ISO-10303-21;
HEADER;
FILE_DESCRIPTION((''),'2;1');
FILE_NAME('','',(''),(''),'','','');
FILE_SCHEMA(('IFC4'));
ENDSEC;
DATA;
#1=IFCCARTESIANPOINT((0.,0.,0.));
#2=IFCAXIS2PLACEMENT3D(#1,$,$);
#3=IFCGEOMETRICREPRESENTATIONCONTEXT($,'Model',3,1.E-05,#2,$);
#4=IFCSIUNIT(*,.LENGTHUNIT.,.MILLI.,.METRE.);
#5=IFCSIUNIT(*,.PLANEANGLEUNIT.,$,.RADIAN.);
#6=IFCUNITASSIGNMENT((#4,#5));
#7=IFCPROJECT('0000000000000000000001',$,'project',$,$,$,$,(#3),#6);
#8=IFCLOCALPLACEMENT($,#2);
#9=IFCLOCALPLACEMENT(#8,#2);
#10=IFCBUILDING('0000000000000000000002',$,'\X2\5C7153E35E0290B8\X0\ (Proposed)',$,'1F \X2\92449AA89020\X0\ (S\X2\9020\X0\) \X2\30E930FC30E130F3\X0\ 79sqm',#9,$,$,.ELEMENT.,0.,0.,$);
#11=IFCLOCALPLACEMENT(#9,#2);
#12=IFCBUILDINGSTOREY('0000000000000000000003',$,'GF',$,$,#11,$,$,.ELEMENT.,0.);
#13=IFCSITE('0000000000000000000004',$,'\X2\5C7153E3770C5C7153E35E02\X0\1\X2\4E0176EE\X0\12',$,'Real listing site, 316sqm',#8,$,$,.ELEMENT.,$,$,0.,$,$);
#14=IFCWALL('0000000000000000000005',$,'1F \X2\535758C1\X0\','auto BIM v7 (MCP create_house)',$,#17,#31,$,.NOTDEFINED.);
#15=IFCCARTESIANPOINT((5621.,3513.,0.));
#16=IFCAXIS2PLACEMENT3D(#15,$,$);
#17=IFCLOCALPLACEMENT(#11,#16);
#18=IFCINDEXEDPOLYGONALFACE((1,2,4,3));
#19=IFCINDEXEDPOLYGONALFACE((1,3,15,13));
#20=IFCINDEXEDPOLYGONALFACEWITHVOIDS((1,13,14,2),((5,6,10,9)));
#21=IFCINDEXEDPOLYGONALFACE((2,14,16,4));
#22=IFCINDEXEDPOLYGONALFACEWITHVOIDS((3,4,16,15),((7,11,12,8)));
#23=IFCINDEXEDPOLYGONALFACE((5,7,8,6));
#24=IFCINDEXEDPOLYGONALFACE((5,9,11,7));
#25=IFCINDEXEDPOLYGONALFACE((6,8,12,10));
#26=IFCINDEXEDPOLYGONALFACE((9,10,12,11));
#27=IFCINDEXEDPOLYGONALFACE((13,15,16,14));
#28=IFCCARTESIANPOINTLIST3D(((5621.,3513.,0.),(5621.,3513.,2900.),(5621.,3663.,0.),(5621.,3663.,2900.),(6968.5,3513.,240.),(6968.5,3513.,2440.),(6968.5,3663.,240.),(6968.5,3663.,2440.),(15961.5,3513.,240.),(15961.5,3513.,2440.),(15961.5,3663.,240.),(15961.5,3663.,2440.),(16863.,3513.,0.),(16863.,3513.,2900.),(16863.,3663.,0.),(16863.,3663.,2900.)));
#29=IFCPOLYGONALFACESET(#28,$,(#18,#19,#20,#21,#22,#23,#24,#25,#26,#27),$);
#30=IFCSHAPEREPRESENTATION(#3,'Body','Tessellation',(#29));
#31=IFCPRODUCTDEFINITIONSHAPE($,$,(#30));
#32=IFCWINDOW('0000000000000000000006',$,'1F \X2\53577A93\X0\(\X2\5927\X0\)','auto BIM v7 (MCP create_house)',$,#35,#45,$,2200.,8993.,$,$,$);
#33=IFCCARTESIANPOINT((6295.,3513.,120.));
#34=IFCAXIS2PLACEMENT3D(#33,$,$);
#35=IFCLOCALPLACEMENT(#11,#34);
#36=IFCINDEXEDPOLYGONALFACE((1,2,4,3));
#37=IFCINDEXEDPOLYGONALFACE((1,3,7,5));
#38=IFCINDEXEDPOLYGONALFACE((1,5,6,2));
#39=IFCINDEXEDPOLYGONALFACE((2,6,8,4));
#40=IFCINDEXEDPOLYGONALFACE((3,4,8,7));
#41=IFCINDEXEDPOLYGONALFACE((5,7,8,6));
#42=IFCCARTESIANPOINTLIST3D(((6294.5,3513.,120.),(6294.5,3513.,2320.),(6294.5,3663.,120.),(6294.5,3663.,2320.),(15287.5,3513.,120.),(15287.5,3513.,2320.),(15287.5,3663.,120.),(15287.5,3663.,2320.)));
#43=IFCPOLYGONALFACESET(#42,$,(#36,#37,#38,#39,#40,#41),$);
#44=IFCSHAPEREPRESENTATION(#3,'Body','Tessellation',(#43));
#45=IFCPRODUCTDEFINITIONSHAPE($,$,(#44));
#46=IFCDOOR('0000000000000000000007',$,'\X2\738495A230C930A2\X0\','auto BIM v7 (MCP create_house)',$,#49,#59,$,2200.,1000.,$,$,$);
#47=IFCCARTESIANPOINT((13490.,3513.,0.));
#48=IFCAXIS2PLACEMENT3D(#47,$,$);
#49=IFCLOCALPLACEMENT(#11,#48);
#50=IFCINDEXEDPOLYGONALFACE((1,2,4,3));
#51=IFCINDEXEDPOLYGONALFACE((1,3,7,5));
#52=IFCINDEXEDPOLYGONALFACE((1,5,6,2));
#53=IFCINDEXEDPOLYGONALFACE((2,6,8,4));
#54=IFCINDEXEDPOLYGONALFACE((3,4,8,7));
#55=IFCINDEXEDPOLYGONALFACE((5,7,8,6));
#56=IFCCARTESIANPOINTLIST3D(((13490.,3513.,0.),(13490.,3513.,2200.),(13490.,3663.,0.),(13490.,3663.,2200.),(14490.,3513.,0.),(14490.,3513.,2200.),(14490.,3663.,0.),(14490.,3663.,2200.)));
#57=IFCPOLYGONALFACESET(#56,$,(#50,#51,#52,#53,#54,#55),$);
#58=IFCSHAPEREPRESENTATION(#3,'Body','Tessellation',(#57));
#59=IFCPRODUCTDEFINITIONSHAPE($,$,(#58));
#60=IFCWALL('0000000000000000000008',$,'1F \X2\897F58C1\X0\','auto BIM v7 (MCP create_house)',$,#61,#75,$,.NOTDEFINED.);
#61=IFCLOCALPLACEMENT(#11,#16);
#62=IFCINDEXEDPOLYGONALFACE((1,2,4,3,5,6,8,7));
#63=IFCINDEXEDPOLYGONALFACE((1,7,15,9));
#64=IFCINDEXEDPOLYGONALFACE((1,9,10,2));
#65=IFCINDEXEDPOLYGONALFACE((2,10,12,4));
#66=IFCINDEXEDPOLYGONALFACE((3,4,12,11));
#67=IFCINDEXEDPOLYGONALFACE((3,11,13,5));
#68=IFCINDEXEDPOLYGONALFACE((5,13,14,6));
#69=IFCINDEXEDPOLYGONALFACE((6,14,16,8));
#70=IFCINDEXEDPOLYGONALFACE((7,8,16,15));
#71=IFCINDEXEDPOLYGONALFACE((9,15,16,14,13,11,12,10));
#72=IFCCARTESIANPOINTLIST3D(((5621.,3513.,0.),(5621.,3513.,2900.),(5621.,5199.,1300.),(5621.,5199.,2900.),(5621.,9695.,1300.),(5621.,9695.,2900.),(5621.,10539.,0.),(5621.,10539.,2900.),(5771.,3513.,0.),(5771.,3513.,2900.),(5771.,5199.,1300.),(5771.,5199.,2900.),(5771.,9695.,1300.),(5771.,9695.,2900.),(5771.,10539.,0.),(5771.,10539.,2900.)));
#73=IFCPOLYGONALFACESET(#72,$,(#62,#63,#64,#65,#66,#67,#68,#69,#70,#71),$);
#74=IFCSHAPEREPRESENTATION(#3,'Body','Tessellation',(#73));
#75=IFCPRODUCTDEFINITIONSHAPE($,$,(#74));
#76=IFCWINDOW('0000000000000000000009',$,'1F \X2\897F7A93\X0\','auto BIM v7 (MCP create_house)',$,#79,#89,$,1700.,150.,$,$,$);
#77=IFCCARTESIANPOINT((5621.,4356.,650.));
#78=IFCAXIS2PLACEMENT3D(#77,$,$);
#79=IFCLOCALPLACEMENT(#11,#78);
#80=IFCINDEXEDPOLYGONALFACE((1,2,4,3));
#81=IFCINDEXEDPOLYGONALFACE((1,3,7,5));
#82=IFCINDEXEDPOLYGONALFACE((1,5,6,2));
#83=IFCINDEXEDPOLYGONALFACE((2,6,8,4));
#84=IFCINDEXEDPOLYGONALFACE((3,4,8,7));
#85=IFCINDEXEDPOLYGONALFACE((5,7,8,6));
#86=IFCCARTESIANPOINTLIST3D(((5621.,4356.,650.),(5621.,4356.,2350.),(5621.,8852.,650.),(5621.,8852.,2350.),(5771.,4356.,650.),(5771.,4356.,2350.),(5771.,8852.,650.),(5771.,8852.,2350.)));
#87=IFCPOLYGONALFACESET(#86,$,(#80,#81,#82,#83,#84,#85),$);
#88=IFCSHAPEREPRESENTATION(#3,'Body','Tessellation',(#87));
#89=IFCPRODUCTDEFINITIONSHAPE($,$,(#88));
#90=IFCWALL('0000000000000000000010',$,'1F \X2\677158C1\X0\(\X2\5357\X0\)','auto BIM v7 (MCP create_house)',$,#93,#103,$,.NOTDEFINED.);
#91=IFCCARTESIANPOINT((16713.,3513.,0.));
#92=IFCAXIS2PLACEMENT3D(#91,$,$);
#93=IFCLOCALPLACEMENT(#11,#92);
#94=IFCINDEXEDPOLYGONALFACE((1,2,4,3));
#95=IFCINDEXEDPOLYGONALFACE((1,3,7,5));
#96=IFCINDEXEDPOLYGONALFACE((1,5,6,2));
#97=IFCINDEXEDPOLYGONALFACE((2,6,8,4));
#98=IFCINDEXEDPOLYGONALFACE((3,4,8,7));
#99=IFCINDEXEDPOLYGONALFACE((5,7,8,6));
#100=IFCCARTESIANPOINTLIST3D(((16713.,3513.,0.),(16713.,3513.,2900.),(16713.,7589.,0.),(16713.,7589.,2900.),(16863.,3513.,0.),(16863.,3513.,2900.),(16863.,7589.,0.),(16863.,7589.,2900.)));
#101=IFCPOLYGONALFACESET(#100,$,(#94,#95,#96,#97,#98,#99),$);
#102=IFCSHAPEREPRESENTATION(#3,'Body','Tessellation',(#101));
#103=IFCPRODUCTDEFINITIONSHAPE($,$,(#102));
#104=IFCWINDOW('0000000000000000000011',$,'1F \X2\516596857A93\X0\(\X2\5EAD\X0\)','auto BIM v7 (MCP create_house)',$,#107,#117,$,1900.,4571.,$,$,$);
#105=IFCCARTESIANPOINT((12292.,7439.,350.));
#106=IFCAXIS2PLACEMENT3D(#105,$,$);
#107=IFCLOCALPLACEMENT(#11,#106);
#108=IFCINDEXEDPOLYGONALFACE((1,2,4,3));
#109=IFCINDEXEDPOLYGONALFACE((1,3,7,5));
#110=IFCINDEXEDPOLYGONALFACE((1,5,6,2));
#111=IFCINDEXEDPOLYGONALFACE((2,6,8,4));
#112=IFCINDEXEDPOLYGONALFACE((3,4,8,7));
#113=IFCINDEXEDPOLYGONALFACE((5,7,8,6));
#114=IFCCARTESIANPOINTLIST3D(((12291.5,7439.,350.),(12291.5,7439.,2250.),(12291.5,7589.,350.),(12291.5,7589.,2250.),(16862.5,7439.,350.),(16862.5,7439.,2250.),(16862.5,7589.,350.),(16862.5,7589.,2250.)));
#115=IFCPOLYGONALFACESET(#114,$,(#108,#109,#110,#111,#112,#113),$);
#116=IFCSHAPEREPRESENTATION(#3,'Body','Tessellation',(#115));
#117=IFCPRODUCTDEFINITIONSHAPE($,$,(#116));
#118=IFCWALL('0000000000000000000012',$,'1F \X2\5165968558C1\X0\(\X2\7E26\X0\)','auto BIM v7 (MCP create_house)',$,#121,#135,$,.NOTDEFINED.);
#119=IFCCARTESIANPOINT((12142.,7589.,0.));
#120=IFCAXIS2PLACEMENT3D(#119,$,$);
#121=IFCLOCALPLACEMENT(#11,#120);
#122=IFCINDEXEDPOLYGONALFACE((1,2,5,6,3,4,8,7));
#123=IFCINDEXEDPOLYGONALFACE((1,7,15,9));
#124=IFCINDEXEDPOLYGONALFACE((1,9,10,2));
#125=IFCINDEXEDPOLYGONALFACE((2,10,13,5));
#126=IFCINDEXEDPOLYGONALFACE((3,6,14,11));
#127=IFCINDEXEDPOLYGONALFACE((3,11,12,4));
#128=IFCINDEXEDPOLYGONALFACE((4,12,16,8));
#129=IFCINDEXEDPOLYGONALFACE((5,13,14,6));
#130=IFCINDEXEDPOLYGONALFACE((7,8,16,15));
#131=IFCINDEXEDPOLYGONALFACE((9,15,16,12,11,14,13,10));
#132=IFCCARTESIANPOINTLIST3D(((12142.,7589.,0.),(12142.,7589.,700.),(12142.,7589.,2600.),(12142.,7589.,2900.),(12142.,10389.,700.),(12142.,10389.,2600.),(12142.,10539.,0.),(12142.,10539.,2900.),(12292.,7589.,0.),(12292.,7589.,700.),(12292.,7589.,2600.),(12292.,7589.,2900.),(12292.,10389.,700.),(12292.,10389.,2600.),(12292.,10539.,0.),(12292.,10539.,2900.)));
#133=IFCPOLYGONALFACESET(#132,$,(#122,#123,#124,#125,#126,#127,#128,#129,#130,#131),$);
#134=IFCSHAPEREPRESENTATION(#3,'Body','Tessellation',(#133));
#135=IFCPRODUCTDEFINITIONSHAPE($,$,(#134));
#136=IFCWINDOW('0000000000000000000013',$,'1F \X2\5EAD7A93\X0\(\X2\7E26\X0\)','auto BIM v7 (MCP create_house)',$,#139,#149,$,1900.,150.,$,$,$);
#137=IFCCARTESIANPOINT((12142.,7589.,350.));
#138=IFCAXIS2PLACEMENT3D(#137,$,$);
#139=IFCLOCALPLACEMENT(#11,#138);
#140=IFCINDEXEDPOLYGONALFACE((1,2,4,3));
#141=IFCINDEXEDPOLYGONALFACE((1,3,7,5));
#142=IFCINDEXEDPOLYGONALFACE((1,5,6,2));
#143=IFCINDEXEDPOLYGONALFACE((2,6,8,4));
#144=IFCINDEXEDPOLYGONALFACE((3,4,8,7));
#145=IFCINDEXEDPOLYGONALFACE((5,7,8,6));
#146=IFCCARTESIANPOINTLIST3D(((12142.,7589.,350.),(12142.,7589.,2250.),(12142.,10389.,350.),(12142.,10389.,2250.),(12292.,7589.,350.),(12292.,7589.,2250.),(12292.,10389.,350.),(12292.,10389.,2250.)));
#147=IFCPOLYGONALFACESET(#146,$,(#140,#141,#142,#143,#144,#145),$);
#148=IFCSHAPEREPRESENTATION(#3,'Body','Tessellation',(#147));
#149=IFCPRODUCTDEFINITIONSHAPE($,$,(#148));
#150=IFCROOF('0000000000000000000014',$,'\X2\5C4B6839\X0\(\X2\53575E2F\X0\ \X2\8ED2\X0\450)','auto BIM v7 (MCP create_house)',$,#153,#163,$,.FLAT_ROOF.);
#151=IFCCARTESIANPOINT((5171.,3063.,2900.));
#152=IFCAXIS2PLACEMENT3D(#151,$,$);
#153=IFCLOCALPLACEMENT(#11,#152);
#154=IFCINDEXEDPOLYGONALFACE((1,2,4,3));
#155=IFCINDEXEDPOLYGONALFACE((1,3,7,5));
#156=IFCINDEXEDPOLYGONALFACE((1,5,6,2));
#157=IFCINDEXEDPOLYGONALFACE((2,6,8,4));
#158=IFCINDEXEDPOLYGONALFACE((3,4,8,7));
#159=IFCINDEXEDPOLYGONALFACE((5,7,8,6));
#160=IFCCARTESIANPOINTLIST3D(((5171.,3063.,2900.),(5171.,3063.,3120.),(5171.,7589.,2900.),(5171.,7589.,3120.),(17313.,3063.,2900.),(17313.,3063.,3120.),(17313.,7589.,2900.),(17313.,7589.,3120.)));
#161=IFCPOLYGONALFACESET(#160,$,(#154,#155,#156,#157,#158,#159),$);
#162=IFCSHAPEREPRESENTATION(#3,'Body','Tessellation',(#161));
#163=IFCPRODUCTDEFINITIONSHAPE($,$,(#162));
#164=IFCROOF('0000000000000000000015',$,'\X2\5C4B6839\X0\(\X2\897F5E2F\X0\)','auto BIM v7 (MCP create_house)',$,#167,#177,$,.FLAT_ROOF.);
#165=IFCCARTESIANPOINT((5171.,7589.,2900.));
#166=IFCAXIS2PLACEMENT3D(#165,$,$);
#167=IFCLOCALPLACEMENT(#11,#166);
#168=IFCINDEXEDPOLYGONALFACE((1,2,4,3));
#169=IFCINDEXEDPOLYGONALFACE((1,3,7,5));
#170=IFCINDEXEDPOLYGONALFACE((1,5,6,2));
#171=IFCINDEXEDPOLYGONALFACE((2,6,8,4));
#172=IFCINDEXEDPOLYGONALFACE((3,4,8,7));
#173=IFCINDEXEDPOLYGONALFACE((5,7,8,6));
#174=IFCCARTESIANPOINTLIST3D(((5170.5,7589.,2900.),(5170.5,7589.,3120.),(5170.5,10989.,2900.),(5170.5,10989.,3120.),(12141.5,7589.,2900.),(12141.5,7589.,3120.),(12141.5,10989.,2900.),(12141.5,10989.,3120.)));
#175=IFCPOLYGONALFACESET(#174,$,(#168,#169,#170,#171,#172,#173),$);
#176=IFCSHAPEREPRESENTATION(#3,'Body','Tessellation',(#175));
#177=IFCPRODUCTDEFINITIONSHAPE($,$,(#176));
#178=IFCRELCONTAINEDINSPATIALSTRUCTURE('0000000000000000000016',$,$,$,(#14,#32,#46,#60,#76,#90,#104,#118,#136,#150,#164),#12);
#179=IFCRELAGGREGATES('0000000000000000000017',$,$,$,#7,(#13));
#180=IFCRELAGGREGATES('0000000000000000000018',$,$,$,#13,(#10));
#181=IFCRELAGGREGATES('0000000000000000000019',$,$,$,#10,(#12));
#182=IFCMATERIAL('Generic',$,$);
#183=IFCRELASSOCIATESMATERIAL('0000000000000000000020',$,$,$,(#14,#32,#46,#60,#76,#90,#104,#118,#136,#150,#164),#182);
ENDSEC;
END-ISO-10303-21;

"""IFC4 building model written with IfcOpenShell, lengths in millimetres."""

from ifc_helpers import new_model, si_unit, frame, frame_2d, origin, place, context, project, spatial, rectangle, extrude, material, element, fill, save


model = new_model("IFC4")

# Units and contexts
model_context = context("Model", 3, precision=1e-05, world=origin())
ifc_project = project(units=[si_unit("LENGTHUNIT", "METRE", prefix="MILLI"), si_unit("PLANEANGLEUNIT", "RADIAN")], contexts=[model_context])

# Site, building, storey
site_placement = place(None, origin())
site = spatial("IfcSite", under=ifc_project, at=site_placement, Name="山口県山口市1丁目12", ObjectType="Real listing site, 316sqm", CompositionType="ELEMENT", RefElevation=0.0)
building_placement = place(site_placement, origin())
building = spatial("IfcBuilding", under=site, at=building_placement, Name="山口市邸 (Proposed)", ObjectType="1F 鉄骨造 (S造) ラーメン 79sqm", CompositionType="ELEMENT", ElevationOfRefHeight=0.0, ElevationOfTerrain=0.0)
storey_placement = place(building_placement, origin())
storey = spatial("IfcBuildingStorey", under=building, at=storey_placement, Name="GF", CompositionType="ELEMENT", Elevation=0.0)

# Shared definitions
ifc_material = material(Name="Generic")

# Wall, openings, window, door
wall_1_placement = place(storey_placement, frame((5621.0, 3513.0, 0.0)))
wall_1 = element("IfcWall", 1, at=wall_1_placement, inside=storey, material=ifc_material, Name="1F 南壁", Description="auto BIM v7 (MCP create_house)", PredefinedType="NOTDEFINED", context=model_context, shape_type="SweptSolid", body=[
    extrude(rectangle(XDim=11242.0, YDim=150.0, at=frame_2d((5621.0, 75.0))), frame((5621.0, 3513.0, 0.0)), (0.0, 0.0, 1.0), 2900.0),
])
opening_1_placement = place(storey_placement, frame((6295.0, 3513.0, 120.0)))
opening_1 = element("IfcOpeningElement", 2, at=opening_1_placement, cuts=wall_1, PredefinedType="NOTDEFINED", context=model_context, shape_type="SweptSolid", body=[
    extrude(rectangle(XDim=8993.0, YDim=150.0, at=frame_2d((4496.0, 75.0))), frame((6295.0, 3513.0, 120.0)), (0.0, 0.0, 1.0), 2200.0),
])
opening_2_placement = place(storey_placement, frame((13490.0, 3513.0, 0.0)))
opening_2 = element("IfcOpeningElement", 3, at=opening_2_placement, cuts=wall_1, PredefinedType="NOTDEFINED", context=model_context, shape_type="SweptSolid", body=[
    extrude(rectangle(XDim=1000.0, YDim=150.0, at=frame_2d((500.0, 75.0))), frame((13490.0, 3513.0, 0.0)), (0.0, 0.0, 1.0), 2200.0),
])
window_1_placement = place(storey_placement, frame((6295.0, 3513.0, 120.0)))
window_1 = element("IfcWindow", 4, at=window_1_placement, inside=storey, material=ifc_material, Name="1F 南窓(大)", Description="auto BIM v7 (MCP create_house)", OverallHeight=2200.0, OverallWidth=8993.0, context=model_context, shape_type="SweptSolid", body=[
    extrude(rectangle(XDim=8993.0, YDim=150.0, at=frame_2d((4496.0, 75.0))), frame((6295.0, 3513.0, 120.0)), (0.0, 0.0, 1.0), 2200.0),
])
fill(opening_1, window_1)
door_placement = place(storey_placement, frame((13490.0, 3513.0, 0.0)))
door = element("IfcDoor", 5, at=door_placement, inside=storey, material=ifc_material, Name="玄関ドア", Description="auto BIM v7 (MCP create_house)", OverallHeight=2200.0, OverallWidth=1000.0, context=model_context, shape_type="SweptSolid", body=[
    extrude(rectangle(XDim=1000.0, YDim=150.0, at=frame_2d((500.0, 75.0))), frame((13490.0, 3513.0, 0.0)), (0.0, 0.0, 1.0), 2200.0),
])
fill(opening_2, door)

# Wall, opening, window
wall_2_placement = place(storey_placement, frame((5621.0, 3513.0, 0.0)))
wall_2 = element("IfcWall", 6, at=wall_2_placement, inside=storey, material=ifc_material, Name="1F 西壁", Description="auto BIM v7 (MCP create_house)", PredefinedType="NOTDEFINED", context=model_context, shape_type="SweptSolid", body=[
    extrude(rectangle(XDim=150.0, YDim=7026.0, at=frame_2d((75.0, 3513.0))), frame((5621.0, 3513.0, 0.0)), (0.0, 0.0, 1.0), 2900.0),
])
opening_3_placement = place(storey_placement, frame((5621.0, 4356.0, 650.0)))
opening_3 = element("IfcOpeningElement", 7, at=opening_3_placement, cuts=wall_2, PredefinedType="NOTDEFINED", context=model_context, shape_type="SweptSolid", body=[
    extrude(rectangle(XDim=150.0, YDim=4496.0, at=frame_2d((75.0, 2248.0))), frame((5621.0, 4356.0, 650.0)), (0.0, 0.0, 1.0), 1700.0),
])
window_2_placement = place(storey_placement, frame((5621.0, 4356.0, 650.0)))
window_2 = element("IfcWindow", 8, at=window_2_placement, inside=storey, material=ifc_material, Name="1F 西窓", Description="auto BIM v7 (MCP create_house)", OverallHeight=1700.0, OverallWidth=150.0, context=model_context, shape_type="SweptSolid", body=[
    extrude(rectangle(XDim=150.0, YDim=4496.0, at=frame_2d((75.0, 2248.0))), frame((5621.0, 4356.0, 650.0)), (0.0, 0.0, 1.0), 1700.0),
])
fill(opening_3, window_2)

# Wall, opening, window
wall_3_placement = place(storey_placement, frame((16713.0, 3513.0, 0.0)))
wall_3 = element("IfcWall", 9, at=wall_3_placement, inside=storey, material=ifc_material, Name="1F 東壁(南)", Description="auto BIM v7 (MCP create_house)", PredefinedType="NOTDEFINED", context=model_context, shape_type="SweptSolid", body=[
    extrude(rectangle(XDim=150.0, YDim=4076.0, at=frame_2d((75.0, 2038.0))), frame((16713.0, 3513.0, 0.0)), (0.0, 0.0, 1.0), 2900.0),
])
opening_4_placement = place(storey_placement, frame((12292.0, 7439.0, 350.0)))
opening_4 = element("IfcOpeningElement", 10, at=opening_4_placement, cuts=wall_3, PredefinedType="NOTDEFINED", context=model_context, shape_type="SweptSolid", body=[
    extrude(rectangle(XDim=4571.0, YDim=150.0, at=frame_2d((2285.0, 75.0))), frame((12292.0, 7439.0, 350.0)), (0.0, 0.0, 1.0), 1900.0),
])
window_3_placement = place(storey_placement, frame((12292.0, 7439.0, 350.0)))
window_3 = element("IfcWindow", 11, at=window_3_placement, inside=storey, material=ifc_material, Name="1F 入隅窓(庭)", Description="auto BIM v7 (MCP create_house)", OverallHeight=1900.0, OverallWidth=4571.0, context=model_context, shape_type="SweptSolid", body=[
    extrude(rectangle(XDim=4571.0, YDim=150.0, at=frame_2d((2285.0, 75.0))), frame((12292.0, 7439.0, 350.0)), (0.0, 0.0, 1.0), 1900.0),
])
fill(opening_4, window_3)

# Wall, opening, window
wall_4_placement = place(storey_placement, frame((12142.0, 7589.0, 0.0)))
wall_4 = element("IfcWall", 12, at=wall_4_placement, inside=storey, material=ifc_material, Name="1F 入隅壁(縦)", Description="auto BIM v7 (MCP create_house)", PredefinedType="NOTDEFINED", context=model_context, shape_type="SweptSolid", body=[
    extrude(rectangle(XDim=150.0, YDim=2950.0, at=frame_2d((75.0, 1475.0))), frame((12142.0, 7589.0, 0.0)), (0.0, 0.0, 1.0), 2900.0),
])
opening_5_placement = place(storey_placement, frame((12142.0, 7589.0, 350.0)))
opening_5 = element("IfcOpeningElement", 13, at=opening_5_placement, cuts=wall_4, PredefinedType="NOTDEFINED", context=model_context, shape_type="SweptSolid", body=[
    extrude(rectangle(XDim=150.0, YDim=2800.0, at=frame_2d((75.0, 1400.0))), frame((12142.0, 7589.0, 350.0)), (0.0, 0.0, 1.0), 1900.0),
])
window_4_placement = place(storey_placement, frame((12142.0, 7589.0, 350.0)))
window_4 = element("IfcWindow", 14, at=window_4_placement, inside=storey, material=ifc_material, Name="1F 庭窓(縦)", Description="auto BIM v7 (MCP create_house)", OverallHeight=1900.0, OverallWidth=150.0, context=model_context, shape_type="SweptSolid", body=[
    extrude(rectangle(XDim=150.0, YDim=2800.0, at=frame_2d((75.0, 1400.0))), frame((12142.0, 7589.0, 350.0)), (0.0, 0.0, 1.0), 1900.0),
])
fill(opening_5, window_4)

# Roofs
roof_1_placement = place(storey_placement, frame((5171.0, 3063.0, 2900.0)))
element("IfcRoof", 15, at=roof_1_placement, inside=storey, material=ifc_material, Name="屋根(南帯 軒450)", Description="auto BIM v7 (MCP create_house)", PredefinedType="FLAT_ROOF", context=model_context, shape_type="SweptSolid", body=[
    extrude(rectangle(XDim=12142.0, YDim=4526.0, at=frame_2d((6071.0, 2263.0))), frame((5171.0, 3063.0, 2900.0)), (0.0, 0.0, 1.0), 220.0),
])
roof_2_placement = place(storey_placement, frame((5171.0, 7589.0, 2900.0)))
element("IfcRoof", 16, at=roof_2_placement, inside=storey, material=ifc_material, Name="屋根(西帯)", Description="auto BIM v7 (MCP create_house)", PredefinedType="FLAT_ROOF", context=model_context, shape_type="SweptSolid", body=[
    extrude(rectangle(XDim=6971.0, YDim=3400.0, at=frame_2d((3485.0, 1700.0))), frame((5171.0, 7589.0, 2900.0)), (0.0, 0.0, 1.0), 220.0),
])

save(model, "model.ifc")
